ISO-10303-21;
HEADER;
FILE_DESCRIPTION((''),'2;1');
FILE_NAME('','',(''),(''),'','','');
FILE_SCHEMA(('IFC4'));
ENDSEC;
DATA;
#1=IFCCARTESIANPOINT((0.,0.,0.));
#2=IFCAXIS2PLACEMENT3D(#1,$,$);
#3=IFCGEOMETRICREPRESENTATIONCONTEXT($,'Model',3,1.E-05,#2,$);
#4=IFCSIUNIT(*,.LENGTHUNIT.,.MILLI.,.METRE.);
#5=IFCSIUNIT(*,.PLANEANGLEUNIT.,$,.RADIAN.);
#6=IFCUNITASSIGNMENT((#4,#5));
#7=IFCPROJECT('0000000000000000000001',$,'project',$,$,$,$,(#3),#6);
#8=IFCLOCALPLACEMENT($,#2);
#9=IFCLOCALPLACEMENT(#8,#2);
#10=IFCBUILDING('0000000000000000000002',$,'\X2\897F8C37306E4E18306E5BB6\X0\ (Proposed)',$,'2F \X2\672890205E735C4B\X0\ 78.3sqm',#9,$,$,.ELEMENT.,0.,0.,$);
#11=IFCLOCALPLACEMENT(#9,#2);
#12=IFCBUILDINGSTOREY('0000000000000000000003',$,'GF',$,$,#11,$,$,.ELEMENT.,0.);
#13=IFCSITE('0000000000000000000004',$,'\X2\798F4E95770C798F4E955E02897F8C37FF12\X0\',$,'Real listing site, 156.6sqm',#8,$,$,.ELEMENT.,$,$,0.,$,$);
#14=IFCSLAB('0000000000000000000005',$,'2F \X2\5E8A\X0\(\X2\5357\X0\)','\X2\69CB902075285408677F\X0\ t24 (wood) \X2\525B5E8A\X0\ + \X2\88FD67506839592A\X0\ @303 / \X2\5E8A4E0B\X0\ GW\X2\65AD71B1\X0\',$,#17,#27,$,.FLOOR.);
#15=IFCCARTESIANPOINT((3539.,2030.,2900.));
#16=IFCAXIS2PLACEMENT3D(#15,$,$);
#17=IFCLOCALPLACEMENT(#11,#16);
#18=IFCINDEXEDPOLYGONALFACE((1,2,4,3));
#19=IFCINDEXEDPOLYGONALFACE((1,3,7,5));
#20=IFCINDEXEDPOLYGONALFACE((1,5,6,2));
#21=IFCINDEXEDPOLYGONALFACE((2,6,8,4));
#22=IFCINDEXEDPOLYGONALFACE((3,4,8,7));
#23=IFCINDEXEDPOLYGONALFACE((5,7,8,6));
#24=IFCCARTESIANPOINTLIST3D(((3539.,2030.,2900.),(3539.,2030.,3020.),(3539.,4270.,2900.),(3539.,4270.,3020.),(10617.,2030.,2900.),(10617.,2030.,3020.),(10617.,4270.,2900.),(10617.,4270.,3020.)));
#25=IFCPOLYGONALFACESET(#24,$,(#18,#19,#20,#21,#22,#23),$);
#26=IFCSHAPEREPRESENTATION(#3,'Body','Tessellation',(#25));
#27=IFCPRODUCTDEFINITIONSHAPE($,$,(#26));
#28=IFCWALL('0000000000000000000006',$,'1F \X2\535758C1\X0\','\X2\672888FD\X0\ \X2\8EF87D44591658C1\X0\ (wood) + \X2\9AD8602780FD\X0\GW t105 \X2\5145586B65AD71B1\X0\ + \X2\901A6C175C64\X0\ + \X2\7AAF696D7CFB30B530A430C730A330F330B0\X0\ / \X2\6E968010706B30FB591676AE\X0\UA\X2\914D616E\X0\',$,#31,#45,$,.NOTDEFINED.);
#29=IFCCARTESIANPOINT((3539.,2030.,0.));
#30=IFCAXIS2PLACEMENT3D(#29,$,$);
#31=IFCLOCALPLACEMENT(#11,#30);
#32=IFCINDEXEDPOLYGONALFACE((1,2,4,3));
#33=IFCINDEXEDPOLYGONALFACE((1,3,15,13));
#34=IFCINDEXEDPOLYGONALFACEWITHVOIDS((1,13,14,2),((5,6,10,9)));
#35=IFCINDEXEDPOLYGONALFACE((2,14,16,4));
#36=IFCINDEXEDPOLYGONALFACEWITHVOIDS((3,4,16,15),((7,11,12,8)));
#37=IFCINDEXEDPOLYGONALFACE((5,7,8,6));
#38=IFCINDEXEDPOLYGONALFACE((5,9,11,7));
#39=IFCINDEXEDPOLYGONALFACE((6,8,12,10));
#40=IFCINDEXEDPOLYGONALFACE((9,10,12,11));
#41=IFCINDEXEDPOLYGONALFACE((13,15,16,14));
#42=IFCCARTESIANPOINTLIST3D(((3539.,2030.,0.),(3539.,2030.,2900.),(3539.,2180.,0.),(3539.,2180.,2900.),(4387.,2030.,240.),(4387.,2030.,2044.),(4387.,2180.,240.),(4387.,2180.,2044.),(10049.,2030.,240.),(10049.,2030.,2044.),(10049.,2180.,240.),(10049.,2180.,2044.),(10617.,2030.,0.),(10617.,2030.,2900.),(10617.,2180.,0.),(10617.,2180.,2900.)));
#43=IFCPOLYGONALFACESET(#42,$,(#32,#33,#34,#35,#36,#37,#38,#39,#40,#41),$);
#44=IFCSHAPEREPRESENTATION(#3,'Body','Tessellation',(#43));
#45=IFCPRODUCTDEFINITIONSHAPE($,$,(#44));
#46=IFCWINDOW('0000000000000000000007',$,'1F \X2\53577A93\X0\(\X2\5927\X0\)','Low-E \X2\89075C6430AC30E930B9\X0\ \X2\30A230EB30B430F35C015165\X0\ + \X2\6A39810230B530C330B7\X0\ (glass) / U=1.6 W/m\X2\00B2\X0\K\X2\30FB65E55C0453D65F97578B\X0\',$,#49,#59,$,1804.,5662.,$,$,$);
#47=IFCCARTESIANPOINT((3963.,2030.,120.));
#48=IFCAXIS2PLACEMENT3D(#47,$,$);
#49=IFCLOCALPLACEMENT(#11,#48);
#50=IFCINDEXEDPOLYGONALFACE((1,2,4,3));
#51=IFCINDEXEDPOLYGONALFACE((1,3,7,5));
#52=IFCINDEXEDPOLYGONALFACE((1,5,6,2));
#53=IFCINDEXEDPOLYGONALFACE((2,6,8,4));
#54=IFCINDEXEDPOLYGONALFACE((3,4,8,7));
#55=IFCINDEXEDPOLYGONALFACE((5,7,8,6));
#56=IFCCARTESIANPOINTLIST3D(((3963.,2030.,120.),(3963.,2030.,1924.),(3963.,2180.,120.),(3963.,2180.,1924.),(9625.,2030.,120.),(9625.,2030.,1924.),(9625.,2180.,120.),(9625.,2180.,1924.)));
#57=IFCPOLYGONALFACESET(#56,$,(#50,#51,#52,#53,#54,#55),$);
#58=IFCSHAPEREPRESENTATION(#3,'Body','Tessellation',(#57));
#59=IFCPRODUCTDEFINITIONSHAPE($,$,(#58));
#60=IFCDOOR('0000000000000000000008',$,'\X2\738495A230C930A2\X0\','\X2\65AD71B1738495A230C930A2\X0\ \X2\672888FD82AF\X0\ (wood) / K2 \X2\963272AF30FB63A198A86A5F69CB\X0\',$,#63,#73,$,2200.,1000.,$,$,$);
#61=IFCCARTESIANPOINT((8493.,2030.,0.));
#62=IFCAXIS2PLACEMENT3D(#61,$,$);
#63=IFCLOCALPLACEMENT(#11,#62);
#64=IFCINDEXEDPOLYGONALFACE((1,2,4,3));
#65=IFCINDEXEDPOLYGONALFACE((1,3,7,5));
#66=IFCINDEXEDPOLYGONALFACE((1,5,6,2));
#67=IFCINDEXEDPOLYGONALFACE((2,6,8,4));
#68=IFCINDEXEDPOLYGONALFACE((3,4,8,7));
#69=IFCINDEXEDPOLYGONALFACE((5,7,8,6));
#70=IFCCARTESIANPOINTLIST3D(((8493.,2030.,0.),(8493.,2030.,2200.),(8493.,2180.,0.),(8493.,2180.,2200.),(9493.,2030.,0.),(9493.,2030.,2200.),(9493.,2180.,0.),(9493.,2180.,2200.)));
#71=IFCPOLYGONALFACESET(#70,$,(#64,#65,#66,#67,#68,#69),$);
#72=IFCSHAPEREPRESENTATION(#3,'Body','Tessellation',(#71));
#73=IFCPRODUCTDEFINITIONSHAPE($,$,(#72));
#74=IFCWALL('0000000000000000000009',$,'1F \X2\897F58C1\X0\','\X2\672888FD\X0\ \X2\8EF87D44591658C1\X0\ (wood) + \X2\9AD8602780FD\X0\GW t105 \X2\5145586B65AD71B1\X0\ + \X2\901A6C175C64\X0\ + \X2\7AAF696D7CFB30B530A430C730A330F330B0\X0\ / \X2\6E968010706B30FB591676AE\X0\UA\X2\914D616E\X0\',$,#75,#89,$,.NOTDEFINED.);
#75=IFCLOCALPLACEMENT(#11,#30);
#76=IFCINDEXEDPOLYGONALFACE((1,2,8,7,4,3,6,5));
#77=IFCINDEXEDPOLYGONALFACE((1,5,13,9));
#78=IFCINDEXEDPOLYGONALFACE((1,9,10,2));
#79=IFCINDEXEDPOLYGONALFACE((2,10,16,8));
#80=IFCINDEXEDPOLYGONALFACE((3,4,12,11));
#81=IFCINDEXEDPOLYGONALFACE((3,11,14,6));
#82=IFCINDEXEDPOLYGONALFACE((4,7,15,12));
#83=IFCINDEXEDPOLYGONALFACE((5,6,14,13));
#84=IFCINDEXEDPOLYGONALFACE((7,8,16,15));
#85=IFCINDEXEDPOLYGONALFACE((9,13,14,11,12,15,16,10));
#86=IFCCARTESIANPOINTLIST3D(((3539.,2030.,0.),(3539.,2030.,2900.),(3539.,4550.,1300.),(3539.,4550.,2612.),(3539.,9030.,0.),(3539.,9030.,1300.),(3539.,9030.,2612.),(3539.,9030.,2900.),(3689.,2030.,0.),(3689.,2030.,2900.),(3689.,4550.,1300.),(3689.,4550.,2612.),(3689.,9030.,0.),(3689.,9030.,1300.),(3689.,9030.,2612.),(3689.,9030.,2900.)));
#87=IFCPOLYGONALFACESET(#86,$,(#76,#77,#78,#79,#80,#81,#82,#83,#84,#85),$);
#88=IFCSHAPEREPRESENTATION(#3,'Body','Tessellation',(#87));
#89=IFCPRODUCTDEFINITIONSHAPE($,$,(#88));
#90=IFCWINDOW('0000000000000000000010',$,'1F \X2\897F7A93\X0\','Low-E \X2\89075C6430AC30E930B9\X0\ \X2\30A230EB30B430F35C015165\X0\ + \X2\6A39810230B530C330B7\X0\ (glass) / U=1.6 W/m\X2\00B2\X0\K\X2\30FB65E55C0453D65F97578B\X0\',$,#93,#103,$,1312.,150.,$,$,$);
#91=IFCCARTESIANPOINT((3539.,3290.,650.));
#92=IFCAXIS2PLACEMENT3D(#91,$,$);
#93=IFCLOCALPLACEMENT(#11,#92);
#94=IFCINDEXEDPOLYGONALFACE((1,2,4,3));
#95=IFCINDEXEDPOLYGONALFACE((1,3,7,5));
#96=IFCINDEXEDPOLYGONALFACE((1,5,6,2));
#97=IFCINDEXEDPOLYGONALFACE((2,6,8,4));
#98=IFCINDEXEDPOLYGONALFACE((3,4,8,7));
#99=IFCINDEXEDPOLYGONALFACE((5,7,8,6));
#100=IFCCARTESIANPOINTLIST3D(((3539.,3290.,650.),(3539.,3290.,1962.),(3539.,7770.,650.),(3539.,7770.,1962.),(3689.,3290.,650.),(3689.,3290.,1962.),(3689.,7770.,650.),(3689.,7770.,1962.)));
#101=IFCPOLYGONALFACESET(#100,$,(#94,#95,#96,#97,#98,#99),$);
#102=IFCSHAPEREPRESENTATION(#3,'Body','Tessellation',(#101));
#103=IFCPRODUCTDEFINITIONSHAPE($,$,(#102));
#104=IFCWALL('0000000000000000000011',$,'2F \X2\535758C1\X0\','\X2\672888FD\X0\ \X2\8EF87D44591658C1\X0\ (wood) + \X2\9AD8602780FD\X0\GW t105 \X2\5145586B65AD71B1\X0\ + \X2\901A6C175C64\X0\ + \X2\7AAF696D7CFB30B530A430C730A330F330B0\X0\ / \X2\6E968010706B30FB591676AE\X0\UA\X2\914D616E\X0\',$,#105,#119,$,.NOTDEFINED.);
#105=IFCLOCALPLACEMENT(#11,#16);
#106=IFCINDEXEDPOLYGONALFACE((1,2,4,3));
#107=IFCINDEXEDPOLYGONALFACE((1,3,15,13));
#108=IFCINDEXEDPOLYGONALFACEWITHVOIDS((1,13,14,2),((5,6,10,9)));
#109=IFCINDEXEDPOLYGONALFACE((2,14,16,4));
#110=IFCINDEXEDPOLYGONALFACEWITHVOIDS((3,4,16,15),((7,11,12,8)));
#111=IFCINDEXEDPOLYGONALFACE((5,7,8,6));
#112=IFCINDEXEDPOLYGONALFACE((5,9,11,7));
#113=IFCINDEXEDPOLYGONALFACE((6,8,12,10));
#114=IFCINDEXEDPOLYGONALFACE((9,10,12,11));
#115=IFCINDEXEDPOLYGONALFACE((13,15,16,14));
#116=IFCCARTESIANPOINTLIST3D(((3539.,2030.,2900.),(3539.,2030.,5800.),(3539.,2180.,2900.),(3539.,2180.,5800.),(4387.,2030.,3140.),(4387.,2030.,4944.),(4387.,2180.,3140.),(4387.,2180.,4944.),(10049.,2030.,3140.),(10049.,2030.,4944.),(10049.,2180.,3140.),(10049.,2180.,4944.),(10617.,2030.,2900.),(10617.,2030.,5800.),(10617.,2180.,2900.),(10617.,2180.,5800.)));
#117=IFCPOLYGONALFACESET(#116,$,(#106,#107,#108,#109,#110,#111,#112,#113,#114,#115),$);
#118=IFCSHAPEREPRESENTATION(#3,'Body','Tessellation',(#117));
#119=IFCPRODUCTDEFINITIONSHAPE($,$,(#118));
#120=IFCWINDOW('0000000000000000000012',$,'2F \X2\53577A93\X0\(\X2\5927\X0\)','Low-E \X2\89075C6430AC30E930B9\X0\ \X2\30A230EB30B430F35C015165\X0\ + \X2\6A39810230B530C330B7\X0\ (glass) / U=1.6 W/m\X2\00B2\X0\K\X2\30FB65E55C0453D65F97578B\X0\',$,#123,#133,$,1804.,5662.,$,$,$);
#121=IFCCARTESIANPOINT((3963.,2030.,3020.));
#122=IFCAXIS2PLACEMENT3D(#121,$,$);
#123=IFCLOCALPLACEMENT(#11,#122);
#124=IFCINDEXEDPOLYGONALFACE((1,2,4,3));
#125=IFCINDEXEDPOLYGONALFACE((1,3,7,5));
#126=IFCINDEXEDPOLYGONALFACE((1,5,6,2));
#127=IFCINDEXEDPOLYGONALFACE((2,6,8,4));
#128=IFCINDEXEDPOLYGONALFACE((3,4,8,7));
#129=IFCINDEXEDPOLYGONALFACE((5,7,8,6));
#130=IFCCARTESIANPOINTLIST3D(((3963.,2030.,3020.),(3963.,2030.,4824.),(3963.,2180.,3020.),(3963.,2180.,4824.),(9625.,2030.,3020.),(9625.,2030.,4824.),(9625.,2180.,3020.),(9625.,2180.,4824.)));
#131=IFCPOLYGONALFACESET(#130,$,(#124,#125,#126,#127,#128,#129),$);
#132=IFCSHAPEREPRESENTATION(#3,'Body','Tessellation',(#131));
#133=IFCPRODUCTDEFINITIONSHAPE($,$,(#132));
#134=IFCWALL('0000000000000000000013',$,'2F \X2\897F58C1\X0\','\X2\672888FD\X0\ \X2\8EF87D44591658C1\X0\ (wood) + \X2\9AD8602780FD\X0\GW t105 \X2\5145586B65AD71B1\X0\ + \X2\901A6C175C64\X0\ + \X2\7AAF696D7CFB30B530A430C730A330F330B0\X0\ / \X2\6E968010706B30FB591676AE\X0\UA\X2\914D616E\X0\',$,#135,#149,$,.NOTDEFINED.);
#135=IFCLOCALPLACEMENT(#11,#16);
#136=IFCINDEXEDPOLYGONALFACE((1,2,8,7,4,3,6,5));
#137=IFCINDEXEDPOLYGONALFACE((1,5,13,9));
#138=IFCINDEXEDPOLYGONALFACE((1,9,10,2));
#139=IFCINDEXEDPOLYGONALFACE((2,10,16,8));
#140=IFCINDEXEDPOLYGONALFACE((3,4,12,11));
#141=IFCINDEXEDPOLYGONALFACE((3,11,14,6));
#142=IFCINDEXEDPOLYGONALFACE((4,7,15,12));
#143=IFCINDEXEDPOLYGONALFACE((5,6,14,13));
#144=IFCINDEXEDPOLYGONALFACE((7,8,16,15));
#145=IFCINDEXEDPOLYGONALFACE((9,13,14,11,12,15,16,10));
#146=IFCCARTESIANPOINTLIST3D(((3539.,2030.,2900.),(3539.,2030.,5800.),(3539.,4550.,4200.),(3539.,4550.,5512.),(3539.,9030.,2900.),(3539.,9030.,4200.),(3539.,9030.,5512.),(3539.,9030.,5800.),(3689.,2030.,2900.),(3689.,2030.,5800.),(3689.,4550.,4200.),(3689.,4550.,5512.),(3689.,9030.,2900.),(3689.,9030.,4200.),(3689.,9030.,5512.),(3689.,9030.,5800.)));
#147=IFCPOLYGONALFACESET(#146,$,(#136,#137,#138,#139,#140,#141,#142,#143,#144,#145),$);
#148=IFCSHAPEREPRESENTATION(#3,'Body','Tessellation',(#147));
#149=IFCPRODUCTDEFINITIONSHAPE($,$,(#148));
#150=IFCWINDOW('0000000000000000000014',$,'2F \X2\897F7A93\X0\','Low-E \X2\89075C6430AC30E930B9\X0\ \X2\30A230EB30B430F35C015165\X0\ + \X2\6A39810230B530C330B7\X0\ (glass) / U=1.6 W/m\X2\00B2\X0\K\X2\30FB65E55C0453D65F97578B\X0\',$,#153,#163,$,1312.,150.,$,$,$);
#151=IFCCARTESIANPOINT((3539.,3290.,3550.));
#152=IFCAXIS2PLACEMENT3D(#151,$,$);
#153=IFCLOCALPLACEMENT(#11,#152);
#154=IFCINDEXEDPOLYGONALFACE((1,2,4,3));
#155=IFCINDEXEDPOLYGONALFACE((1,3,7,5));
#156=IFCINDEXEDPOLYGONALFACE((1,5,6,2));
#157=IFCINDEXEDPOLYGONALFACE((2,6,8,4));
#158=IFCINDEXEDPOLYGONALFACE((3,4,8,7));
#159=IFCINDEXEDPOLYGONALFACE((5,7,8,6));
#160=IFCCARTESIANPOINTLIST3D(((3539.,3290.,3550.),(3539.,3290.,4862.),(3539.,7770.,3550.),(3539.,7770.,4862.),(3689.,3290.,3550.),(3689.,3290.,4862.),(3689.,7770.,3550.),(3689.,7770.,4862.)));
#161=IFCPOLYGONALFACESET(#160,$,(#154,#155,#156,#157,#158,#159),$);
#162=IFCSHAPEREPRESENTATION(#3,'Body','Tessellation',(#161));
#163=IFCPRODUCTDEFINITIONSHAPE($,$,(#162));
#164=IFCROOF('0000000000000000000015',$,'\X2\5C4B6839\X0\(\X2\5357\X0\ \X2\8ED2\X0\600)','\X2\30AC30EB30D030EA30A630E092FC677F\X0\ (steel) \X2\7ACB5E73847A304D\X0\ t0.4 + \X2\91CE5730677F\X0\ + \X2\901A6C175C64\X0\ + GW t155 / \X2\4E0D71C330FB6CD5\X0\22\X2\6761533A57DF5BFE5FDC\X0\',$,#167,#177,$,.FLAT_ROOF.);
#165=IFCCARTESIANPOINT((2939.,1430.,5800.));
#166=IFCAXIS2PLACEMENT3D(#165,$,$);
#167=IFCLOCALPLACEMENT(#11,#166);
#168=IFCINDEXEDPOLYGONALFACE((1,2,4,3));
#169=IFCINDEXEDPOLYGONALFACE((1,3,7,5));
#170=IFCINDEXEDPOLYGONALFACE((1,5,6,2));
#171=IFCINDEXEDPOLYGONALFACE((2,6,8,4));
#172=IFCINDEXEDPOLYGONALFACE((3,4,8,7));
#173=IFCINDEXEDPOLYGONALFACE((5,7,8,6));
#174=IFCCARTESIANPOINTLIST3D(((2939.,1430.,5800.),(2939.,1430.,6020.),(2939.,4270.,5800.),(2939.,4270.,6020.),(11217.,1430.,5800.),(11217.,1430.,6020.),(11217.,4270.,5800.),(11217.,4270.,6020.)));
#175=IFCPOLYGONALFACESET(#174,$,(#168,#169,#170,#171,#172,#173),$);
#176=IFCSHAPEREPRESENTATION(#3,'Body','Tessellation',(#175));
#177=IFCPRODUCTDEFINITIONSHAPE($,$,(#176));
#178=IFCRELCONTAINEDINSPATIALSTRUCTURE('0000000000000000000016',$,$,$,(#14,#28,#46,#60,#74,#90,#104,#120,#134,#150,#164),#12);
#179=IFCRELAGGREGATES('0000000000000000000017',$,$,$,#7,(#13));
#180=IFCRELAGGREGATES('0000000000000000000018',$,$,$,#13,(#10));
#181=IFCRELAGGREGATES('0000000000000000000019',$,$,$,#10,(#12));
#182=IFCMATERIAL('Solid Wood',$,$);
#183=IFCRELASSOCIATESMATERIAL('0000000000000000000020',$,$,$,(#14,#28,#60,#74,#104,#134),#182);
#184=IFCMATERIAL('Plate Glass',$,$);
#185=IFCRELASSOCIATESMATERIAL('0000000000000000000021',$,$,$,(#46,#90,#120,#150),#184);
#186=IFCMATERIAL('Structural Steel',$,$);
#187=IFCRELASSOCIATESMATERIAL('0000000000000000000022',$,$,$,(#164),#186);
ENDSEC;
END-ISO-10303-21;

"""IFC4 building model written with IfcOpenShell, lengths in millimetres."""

from ifc_helpers import new_model, si_unit, frame, frame_2d, origin, place, context, project, spatial, rectangle, extrude, material, element, fill, save


model = new_model("IFC4")

# Units and contexts
model_context = context("Model", 3, precision=1e-05, world=origin())
ifc_project = project(units=[si_unit("LENGTHUNIT", "METRE", prefix="MILLI"), si_unit("PLANEANGLEUNIT", "RADIAN")], contexts=[model_context])

# Site, building, storey
site_placement = place(None, origin())
site = spatial("IfcSite", under=ifc_project, at=site_placement, Name="福井県福井市西谷２", ObjectType="Real listing site, 156.6sqm", CompositionType="ELEMENT", RefElevation=0.0)
building_placement = place(site_placement, origin())
building = spatial("IfcBuilding", under=site, at=building_placement, Name="西谷の丘の家 (Proposed)", ObjectType="2F 木造平屋 78.3sqm", CompositionType="ELEMENT", ElevationOfRefHeight=0.0, ElevationOfTerrain=0.0)
storey_placement = place(building_placement, origin())
storey = spatial("IfcBuildingStorey", under=building, at=storey_placement, Name="GF", CompositionType="ELEMENT", Elevation=0.0)

# Slab
ifc_material_1 = material(Name="Solid Wood")
slab_1_placement = place(storey_placement, frame((3539.0, 2030.0, 2900.0)))
element("IfcSlab", 1, at=slab_1_placement, inside=storey, material=ifc_material_1, Name="2F 床(南)", Description="構造用合板 t24 (wood) 剛床 + 製材根太 @303 / 床下 GW断熱", PredefinedType="FLOOR", context=model_context, shape_type="SweptSolid", body=[
    extrude(rectangle(XDim=7078.0, YDim=2240.0, at=frame_2d((3539.0, 1120.0))), frame((3539.0, 2030.0, 2900.0)), (0.0, 0.0, 1.0), 120.0),
])

# Wall, openings, window, door
wall_1_placement = place(storey_placement, frame((3539.0, 2030.0, 0.0)))
wall_1 = element("IfcWall", 2, at=wall_1_placement, inside=storey, material=ifc_material_1, Name="1F 南壁", Description="木製 軸組外壁 (wood) + 高性能GW t105 充填断熱 + 通気層 + 窯業系サイディング / 準耐火・外皮UA配慮", PredefinedType="NOTDEFINED", context=model_context, shape_type="SweptSolid", body=[
    extrude(rectangle(XDim=7078.0, YDim=150.0, at=frame_2d((3539.0, 75.0))), frame((3539.0, 2030.0, 0.0)), (0.0, 0.0, 1.0), 2900.0),
])
opening_1_placement = place(storey_placement, frame((3963.0, 2030.0, 120.0)))
opening_1 = element("IfcOpeningElement", 3, at=opening_1_placement, cuts=wall_1, PredefinedType="NOTDEFINED", context=model_context, shape_type="SweptSolid", body=[
    extrude(rectangle(XDim=5662.0, YDim=150.0, at=frame_2d((2831.0, 75.0))), frame((3963.0, 2030.0, 120.0)), (0.0, 0.0, 1.0), 1804.0),
])
opening_2_placement = place(storey_placement, frame((8493.0, 2030.0, 0.0)))
opening_2 = element("IfcOpeningElement", 4, at=opening_2_placement, cuts=wall_1, PredefinedType="NOTDEFINED", context=model_context, shape_type="SweptSolid", body=[
    extrude(rectangle(XDim=1000.0, YDim=150.0, at=frame_2d((500.0, 75.0))), frame((8493.0, 2030.0, 0.0)), (0.0, 0.0, 1.0), 2200.0),
])
ifc_material_2 = material(Name="Plate Glass")
window_1_placement = place(storey_placement, frame((3963.0, 2030.0, 120.0)))
window_1 = element("IfcWindow", 5, at=window_1_placement, inside=storey, material=ifc_material_2, Name="1F 南窓(大)", Description="Low-E 複層ガラス アルゴン封入 + 樹脂サッシ (glass) / U=1.6 W/m²K・日射取得型", OverallHeight=1804.0, OverallWidth=5662.0, context=model_context, shape_type="SweptSolid", body=[
    extrude(rectangle(XDim=5662.0, YDim=150.0, at=frame_2d((2831.0, 75.0))), frame((3963.0, 2030.0, 120.0)), (0.0, 0.0, 1.0), 1804.0),
])
fill(opening_1, window_1)
door_placement = place(storey_placement, frame((8493.0, 2030.0, 0.0)))
door = element("IfcDoor", 6, at=door_placement, inside=storey, material=ifc_material_1, Name="玄関ドア", Description="断熱玄関ドア 木製芯 (wood) / K2 防犯・採風機構", OverallHeight=2200.0, OverallWidth=1000.0, context=model_context, shape_type="SweptSolid", body=[
    extrude(rectangle(XDim=1000.0, YDim=150.0, at=frame_2d((500.0, 75.0))), frame((8493.0, 2030.0, 0.0)), (0.0, 0.0, 1.0), 2200.0),
])
fill(opening_2, door)

# Walls, openings, windows
wall_2_placement = place(storey_placement, frame((3539.0, 2030.0, 0.0)))
wall_2 = element("IfcWall", 7, at=wall_2_placement, inside=storey, material=ifc_material_1, Name="1F 西壁", Description="木製 軸組外壁 (wood) + 高性能GW t105 充填断熱 + 通気層 + 窯業系サイディング / 準耐火・外皮UA配慮", PredefinedType="NOTDEFINED", context=model_context, shape_type="SweptSolid", body=[
    extrude(rectangle(XDim=150.0, YDim=7000.0, at=frame_2d((75.0, 3500.0))), frame((3539.0, 2030.0, 0.0)), (0.0, 0.0, 1.0), 2900.0),
])
opening_3_placement = place(storey_placement, frame((3539.0, 3290.0, 650.0)))
opening_3 = element("IfcOpeningElement", 8, at=opening_3_placement, cuts=wall_2, PredefinedType="NOTDEFINED", context=model_context, shape_type="SweptSolid", body=[
    extrude(rectangle(XDim=150.0, YDim=4480.0, at=frame_2d((75.0, 2240.0))), frame((3539.0, 3290.0, 650.0)), (0.0, 0.0, 1.0), 1312.0),
])
window_2_placement = place(storey_placement, frame((3539.0, 3290.0, 650.0)))
window_2 = element("IfcWindow", 9, at=window_2_placement, inside=storey, material=ifc_material_2, Name="1F 西窓", Description="Low-E 複層ガラス アルゴン封入 + 樹脂サッシ (glass) / U=1.6 W/m²K・日射取得型", OverallHeight=1312.0, OverallWidth=150.0, context=model_context, shape_type="SweptSolid", body=[
    extrude(rectangle(XDim=150.0, YDim=4480.0, at=frame_2d((75.0, 2240.0))), frame((3539.0, 3290.0, 650.0)), (0.0, 0.0, 1.0), 1312.0),
])
fill(opening_3, window_2)
wall_3_placement = place(storey_placement, frame((3539.0, 2030.0, 2900.0)))
wall_3 = element("IfcWall", 10, at=wall_3_placement, inside=storey, material=ifc_material_1, Name="2F 南壁", Description="木製 軸組外壁 (wood) + 高性能GW t105 充填断熱 + 通気層 + 窯業系サイディング / 準耐火・外皮UA配慮", PredefinedType="NOTDEFINED", context=model_context, shape_type="SweptSolid", body=[
    extrude(rectangle(XDim=7078.0, YDim=150.0, at=frame_2d((3539.0, 75.0))), frame((3539.0, 2030.0, 2900.0)), (0.0, 0.0, 1.0), 2900.0),
])
opening_4_placement = place(storey_placement, frame((3963.0, 2030.0, 3020.0)))
opening_4 = element("IfcOpeningElement", 11, at=opening_4_placement, cuts=wall_3, PredefinedType="NOTDEFINED", context=model_context, shape_type="SweptSolid", body=[
    extrude(rectangle(XDim=5662.0, YDim=150.0, at=frame_2d((2831.0, 75.0))), frame((3963.0, 2030.0, 3020.0)), (0.0, 0.0, 1.0), 1804.0),
])
window_3_placement = place(storey_placement, frame((3963.0, 2030.0, 3020.0)))
window_3 = element("IfcWindow", 12, at=window_3_placement, inside=storey, material=ifc_material_2, Name="2F 南窓(大)", Description="Low-E 複層ガラス アルゴン封入 + 樹脂サッシ (glass) / U=1.6 W/m²K・日射取得型", OverallHeight=1804.0, OverallWidth=5662.0, context=model_context, shape_type="SweptSolid", body=[
    extrude(rectangle(XDim=5662.0, YDim=150.0, at=frame_2d((2831.0, 75.0))), frame((3963.0, 2030.0, 3020.0)), (0.0, 0.0, 1.0), 1804.0),
])
fill(opening_4, window_3)
wall_4_placement = place(storey_placement, frame((3539.0, 2030.0, 2900.0)))
wall_4 = element("IfcWall", 13, at=wall_4_placement, inside=storey, material=ifc_material_1, Name="2F 西壁", Description="木製 軸組外壁 (wood) + 高性能GW t105 充填断熱 + 通気層 + 窯業系サイディング / 準耐火・外皮UA配慮", PredefinedType="NOTDEFINED", context=model_context, shape_type="SweptSolid", body=[
    extrude(rectangle(XDim=150.0, YDim=7000.0, at=frame_2d((75.0, 3500.0))), frame((3539.0, 2030.0, 2900.0)), (0.0, 0.0, 1.0), 2900.0),
])
opening_5_placement = place(storey_placement, frame((3539.0, 3290.0, 3550.0)))
opening_5 = element("IfcOpeningElement", 14, at=opening_5_placement, cuts=wall_4, PredefinedType="NOTDEFINED", context=model_context, shape_type="SweptSolid", body=[
    extrude(rectangle(XDim=150.0, YDim=4480.0, at=frame_2d((75.0, 2240.0))), frame((3539.0, 3290.0, 3550.0)), (0.0, 0.0, 1.0), 1312.0),
])
window_4_placement = place(storey_placement, frame((3539.0, 3290.0, 3550.0)))
window_4 = element("IfcWindow", 15, at=window_4_placement, inside=storey, material=ifc_material_2, Name="2F 西窓", Description="Low-E 複層ガラス アルゴン封入 + 樹脂サッシ (glass) / U=1.6 W/m²K・日射取得型", OverallHeight=1312.0, OverallWidth=150.0, context=model_context, shape_type="SweptSolid", body=[
    extrude(rectangle(XDim=150.0, YDim=4480.0, at=frame_2d((75.0, 2240.0))), frame((3539.0, 3290.0, 3550.0)), (0.0, 0.0, 1.0), 1312.0),
])
fill(opening_5, window_4)

# Roof
ifc_material_3 = material(Name="Structural Steel")
roof_1_placement = place(storey_placement, frame((2939.0, 1430.0, 5800.0)))
element("IfcRoof", 16, at=roof_1_placement, inside=storey, material=ifc_material_3, Name="屋根(南 軒600)", Description="ガルバリウム鋼板 (steel) 立平葺き t0.4 + 野地板 + 通気層 + GW t155 / 不燃・法22条区域対応", PredefinedType="FLAT_ROOF", context=model_context, shape_type="SweptSolid", body=[
    extrude(rectangle(XDim=8278.0, YDim=2840.0, at=frame_2d((4139.0, 1420.0))), frame((2939.0, 1430.0, 5800.0)), (0.0, 0.0, 1.0), 220.0),
])

save(model, "model.ifc")
